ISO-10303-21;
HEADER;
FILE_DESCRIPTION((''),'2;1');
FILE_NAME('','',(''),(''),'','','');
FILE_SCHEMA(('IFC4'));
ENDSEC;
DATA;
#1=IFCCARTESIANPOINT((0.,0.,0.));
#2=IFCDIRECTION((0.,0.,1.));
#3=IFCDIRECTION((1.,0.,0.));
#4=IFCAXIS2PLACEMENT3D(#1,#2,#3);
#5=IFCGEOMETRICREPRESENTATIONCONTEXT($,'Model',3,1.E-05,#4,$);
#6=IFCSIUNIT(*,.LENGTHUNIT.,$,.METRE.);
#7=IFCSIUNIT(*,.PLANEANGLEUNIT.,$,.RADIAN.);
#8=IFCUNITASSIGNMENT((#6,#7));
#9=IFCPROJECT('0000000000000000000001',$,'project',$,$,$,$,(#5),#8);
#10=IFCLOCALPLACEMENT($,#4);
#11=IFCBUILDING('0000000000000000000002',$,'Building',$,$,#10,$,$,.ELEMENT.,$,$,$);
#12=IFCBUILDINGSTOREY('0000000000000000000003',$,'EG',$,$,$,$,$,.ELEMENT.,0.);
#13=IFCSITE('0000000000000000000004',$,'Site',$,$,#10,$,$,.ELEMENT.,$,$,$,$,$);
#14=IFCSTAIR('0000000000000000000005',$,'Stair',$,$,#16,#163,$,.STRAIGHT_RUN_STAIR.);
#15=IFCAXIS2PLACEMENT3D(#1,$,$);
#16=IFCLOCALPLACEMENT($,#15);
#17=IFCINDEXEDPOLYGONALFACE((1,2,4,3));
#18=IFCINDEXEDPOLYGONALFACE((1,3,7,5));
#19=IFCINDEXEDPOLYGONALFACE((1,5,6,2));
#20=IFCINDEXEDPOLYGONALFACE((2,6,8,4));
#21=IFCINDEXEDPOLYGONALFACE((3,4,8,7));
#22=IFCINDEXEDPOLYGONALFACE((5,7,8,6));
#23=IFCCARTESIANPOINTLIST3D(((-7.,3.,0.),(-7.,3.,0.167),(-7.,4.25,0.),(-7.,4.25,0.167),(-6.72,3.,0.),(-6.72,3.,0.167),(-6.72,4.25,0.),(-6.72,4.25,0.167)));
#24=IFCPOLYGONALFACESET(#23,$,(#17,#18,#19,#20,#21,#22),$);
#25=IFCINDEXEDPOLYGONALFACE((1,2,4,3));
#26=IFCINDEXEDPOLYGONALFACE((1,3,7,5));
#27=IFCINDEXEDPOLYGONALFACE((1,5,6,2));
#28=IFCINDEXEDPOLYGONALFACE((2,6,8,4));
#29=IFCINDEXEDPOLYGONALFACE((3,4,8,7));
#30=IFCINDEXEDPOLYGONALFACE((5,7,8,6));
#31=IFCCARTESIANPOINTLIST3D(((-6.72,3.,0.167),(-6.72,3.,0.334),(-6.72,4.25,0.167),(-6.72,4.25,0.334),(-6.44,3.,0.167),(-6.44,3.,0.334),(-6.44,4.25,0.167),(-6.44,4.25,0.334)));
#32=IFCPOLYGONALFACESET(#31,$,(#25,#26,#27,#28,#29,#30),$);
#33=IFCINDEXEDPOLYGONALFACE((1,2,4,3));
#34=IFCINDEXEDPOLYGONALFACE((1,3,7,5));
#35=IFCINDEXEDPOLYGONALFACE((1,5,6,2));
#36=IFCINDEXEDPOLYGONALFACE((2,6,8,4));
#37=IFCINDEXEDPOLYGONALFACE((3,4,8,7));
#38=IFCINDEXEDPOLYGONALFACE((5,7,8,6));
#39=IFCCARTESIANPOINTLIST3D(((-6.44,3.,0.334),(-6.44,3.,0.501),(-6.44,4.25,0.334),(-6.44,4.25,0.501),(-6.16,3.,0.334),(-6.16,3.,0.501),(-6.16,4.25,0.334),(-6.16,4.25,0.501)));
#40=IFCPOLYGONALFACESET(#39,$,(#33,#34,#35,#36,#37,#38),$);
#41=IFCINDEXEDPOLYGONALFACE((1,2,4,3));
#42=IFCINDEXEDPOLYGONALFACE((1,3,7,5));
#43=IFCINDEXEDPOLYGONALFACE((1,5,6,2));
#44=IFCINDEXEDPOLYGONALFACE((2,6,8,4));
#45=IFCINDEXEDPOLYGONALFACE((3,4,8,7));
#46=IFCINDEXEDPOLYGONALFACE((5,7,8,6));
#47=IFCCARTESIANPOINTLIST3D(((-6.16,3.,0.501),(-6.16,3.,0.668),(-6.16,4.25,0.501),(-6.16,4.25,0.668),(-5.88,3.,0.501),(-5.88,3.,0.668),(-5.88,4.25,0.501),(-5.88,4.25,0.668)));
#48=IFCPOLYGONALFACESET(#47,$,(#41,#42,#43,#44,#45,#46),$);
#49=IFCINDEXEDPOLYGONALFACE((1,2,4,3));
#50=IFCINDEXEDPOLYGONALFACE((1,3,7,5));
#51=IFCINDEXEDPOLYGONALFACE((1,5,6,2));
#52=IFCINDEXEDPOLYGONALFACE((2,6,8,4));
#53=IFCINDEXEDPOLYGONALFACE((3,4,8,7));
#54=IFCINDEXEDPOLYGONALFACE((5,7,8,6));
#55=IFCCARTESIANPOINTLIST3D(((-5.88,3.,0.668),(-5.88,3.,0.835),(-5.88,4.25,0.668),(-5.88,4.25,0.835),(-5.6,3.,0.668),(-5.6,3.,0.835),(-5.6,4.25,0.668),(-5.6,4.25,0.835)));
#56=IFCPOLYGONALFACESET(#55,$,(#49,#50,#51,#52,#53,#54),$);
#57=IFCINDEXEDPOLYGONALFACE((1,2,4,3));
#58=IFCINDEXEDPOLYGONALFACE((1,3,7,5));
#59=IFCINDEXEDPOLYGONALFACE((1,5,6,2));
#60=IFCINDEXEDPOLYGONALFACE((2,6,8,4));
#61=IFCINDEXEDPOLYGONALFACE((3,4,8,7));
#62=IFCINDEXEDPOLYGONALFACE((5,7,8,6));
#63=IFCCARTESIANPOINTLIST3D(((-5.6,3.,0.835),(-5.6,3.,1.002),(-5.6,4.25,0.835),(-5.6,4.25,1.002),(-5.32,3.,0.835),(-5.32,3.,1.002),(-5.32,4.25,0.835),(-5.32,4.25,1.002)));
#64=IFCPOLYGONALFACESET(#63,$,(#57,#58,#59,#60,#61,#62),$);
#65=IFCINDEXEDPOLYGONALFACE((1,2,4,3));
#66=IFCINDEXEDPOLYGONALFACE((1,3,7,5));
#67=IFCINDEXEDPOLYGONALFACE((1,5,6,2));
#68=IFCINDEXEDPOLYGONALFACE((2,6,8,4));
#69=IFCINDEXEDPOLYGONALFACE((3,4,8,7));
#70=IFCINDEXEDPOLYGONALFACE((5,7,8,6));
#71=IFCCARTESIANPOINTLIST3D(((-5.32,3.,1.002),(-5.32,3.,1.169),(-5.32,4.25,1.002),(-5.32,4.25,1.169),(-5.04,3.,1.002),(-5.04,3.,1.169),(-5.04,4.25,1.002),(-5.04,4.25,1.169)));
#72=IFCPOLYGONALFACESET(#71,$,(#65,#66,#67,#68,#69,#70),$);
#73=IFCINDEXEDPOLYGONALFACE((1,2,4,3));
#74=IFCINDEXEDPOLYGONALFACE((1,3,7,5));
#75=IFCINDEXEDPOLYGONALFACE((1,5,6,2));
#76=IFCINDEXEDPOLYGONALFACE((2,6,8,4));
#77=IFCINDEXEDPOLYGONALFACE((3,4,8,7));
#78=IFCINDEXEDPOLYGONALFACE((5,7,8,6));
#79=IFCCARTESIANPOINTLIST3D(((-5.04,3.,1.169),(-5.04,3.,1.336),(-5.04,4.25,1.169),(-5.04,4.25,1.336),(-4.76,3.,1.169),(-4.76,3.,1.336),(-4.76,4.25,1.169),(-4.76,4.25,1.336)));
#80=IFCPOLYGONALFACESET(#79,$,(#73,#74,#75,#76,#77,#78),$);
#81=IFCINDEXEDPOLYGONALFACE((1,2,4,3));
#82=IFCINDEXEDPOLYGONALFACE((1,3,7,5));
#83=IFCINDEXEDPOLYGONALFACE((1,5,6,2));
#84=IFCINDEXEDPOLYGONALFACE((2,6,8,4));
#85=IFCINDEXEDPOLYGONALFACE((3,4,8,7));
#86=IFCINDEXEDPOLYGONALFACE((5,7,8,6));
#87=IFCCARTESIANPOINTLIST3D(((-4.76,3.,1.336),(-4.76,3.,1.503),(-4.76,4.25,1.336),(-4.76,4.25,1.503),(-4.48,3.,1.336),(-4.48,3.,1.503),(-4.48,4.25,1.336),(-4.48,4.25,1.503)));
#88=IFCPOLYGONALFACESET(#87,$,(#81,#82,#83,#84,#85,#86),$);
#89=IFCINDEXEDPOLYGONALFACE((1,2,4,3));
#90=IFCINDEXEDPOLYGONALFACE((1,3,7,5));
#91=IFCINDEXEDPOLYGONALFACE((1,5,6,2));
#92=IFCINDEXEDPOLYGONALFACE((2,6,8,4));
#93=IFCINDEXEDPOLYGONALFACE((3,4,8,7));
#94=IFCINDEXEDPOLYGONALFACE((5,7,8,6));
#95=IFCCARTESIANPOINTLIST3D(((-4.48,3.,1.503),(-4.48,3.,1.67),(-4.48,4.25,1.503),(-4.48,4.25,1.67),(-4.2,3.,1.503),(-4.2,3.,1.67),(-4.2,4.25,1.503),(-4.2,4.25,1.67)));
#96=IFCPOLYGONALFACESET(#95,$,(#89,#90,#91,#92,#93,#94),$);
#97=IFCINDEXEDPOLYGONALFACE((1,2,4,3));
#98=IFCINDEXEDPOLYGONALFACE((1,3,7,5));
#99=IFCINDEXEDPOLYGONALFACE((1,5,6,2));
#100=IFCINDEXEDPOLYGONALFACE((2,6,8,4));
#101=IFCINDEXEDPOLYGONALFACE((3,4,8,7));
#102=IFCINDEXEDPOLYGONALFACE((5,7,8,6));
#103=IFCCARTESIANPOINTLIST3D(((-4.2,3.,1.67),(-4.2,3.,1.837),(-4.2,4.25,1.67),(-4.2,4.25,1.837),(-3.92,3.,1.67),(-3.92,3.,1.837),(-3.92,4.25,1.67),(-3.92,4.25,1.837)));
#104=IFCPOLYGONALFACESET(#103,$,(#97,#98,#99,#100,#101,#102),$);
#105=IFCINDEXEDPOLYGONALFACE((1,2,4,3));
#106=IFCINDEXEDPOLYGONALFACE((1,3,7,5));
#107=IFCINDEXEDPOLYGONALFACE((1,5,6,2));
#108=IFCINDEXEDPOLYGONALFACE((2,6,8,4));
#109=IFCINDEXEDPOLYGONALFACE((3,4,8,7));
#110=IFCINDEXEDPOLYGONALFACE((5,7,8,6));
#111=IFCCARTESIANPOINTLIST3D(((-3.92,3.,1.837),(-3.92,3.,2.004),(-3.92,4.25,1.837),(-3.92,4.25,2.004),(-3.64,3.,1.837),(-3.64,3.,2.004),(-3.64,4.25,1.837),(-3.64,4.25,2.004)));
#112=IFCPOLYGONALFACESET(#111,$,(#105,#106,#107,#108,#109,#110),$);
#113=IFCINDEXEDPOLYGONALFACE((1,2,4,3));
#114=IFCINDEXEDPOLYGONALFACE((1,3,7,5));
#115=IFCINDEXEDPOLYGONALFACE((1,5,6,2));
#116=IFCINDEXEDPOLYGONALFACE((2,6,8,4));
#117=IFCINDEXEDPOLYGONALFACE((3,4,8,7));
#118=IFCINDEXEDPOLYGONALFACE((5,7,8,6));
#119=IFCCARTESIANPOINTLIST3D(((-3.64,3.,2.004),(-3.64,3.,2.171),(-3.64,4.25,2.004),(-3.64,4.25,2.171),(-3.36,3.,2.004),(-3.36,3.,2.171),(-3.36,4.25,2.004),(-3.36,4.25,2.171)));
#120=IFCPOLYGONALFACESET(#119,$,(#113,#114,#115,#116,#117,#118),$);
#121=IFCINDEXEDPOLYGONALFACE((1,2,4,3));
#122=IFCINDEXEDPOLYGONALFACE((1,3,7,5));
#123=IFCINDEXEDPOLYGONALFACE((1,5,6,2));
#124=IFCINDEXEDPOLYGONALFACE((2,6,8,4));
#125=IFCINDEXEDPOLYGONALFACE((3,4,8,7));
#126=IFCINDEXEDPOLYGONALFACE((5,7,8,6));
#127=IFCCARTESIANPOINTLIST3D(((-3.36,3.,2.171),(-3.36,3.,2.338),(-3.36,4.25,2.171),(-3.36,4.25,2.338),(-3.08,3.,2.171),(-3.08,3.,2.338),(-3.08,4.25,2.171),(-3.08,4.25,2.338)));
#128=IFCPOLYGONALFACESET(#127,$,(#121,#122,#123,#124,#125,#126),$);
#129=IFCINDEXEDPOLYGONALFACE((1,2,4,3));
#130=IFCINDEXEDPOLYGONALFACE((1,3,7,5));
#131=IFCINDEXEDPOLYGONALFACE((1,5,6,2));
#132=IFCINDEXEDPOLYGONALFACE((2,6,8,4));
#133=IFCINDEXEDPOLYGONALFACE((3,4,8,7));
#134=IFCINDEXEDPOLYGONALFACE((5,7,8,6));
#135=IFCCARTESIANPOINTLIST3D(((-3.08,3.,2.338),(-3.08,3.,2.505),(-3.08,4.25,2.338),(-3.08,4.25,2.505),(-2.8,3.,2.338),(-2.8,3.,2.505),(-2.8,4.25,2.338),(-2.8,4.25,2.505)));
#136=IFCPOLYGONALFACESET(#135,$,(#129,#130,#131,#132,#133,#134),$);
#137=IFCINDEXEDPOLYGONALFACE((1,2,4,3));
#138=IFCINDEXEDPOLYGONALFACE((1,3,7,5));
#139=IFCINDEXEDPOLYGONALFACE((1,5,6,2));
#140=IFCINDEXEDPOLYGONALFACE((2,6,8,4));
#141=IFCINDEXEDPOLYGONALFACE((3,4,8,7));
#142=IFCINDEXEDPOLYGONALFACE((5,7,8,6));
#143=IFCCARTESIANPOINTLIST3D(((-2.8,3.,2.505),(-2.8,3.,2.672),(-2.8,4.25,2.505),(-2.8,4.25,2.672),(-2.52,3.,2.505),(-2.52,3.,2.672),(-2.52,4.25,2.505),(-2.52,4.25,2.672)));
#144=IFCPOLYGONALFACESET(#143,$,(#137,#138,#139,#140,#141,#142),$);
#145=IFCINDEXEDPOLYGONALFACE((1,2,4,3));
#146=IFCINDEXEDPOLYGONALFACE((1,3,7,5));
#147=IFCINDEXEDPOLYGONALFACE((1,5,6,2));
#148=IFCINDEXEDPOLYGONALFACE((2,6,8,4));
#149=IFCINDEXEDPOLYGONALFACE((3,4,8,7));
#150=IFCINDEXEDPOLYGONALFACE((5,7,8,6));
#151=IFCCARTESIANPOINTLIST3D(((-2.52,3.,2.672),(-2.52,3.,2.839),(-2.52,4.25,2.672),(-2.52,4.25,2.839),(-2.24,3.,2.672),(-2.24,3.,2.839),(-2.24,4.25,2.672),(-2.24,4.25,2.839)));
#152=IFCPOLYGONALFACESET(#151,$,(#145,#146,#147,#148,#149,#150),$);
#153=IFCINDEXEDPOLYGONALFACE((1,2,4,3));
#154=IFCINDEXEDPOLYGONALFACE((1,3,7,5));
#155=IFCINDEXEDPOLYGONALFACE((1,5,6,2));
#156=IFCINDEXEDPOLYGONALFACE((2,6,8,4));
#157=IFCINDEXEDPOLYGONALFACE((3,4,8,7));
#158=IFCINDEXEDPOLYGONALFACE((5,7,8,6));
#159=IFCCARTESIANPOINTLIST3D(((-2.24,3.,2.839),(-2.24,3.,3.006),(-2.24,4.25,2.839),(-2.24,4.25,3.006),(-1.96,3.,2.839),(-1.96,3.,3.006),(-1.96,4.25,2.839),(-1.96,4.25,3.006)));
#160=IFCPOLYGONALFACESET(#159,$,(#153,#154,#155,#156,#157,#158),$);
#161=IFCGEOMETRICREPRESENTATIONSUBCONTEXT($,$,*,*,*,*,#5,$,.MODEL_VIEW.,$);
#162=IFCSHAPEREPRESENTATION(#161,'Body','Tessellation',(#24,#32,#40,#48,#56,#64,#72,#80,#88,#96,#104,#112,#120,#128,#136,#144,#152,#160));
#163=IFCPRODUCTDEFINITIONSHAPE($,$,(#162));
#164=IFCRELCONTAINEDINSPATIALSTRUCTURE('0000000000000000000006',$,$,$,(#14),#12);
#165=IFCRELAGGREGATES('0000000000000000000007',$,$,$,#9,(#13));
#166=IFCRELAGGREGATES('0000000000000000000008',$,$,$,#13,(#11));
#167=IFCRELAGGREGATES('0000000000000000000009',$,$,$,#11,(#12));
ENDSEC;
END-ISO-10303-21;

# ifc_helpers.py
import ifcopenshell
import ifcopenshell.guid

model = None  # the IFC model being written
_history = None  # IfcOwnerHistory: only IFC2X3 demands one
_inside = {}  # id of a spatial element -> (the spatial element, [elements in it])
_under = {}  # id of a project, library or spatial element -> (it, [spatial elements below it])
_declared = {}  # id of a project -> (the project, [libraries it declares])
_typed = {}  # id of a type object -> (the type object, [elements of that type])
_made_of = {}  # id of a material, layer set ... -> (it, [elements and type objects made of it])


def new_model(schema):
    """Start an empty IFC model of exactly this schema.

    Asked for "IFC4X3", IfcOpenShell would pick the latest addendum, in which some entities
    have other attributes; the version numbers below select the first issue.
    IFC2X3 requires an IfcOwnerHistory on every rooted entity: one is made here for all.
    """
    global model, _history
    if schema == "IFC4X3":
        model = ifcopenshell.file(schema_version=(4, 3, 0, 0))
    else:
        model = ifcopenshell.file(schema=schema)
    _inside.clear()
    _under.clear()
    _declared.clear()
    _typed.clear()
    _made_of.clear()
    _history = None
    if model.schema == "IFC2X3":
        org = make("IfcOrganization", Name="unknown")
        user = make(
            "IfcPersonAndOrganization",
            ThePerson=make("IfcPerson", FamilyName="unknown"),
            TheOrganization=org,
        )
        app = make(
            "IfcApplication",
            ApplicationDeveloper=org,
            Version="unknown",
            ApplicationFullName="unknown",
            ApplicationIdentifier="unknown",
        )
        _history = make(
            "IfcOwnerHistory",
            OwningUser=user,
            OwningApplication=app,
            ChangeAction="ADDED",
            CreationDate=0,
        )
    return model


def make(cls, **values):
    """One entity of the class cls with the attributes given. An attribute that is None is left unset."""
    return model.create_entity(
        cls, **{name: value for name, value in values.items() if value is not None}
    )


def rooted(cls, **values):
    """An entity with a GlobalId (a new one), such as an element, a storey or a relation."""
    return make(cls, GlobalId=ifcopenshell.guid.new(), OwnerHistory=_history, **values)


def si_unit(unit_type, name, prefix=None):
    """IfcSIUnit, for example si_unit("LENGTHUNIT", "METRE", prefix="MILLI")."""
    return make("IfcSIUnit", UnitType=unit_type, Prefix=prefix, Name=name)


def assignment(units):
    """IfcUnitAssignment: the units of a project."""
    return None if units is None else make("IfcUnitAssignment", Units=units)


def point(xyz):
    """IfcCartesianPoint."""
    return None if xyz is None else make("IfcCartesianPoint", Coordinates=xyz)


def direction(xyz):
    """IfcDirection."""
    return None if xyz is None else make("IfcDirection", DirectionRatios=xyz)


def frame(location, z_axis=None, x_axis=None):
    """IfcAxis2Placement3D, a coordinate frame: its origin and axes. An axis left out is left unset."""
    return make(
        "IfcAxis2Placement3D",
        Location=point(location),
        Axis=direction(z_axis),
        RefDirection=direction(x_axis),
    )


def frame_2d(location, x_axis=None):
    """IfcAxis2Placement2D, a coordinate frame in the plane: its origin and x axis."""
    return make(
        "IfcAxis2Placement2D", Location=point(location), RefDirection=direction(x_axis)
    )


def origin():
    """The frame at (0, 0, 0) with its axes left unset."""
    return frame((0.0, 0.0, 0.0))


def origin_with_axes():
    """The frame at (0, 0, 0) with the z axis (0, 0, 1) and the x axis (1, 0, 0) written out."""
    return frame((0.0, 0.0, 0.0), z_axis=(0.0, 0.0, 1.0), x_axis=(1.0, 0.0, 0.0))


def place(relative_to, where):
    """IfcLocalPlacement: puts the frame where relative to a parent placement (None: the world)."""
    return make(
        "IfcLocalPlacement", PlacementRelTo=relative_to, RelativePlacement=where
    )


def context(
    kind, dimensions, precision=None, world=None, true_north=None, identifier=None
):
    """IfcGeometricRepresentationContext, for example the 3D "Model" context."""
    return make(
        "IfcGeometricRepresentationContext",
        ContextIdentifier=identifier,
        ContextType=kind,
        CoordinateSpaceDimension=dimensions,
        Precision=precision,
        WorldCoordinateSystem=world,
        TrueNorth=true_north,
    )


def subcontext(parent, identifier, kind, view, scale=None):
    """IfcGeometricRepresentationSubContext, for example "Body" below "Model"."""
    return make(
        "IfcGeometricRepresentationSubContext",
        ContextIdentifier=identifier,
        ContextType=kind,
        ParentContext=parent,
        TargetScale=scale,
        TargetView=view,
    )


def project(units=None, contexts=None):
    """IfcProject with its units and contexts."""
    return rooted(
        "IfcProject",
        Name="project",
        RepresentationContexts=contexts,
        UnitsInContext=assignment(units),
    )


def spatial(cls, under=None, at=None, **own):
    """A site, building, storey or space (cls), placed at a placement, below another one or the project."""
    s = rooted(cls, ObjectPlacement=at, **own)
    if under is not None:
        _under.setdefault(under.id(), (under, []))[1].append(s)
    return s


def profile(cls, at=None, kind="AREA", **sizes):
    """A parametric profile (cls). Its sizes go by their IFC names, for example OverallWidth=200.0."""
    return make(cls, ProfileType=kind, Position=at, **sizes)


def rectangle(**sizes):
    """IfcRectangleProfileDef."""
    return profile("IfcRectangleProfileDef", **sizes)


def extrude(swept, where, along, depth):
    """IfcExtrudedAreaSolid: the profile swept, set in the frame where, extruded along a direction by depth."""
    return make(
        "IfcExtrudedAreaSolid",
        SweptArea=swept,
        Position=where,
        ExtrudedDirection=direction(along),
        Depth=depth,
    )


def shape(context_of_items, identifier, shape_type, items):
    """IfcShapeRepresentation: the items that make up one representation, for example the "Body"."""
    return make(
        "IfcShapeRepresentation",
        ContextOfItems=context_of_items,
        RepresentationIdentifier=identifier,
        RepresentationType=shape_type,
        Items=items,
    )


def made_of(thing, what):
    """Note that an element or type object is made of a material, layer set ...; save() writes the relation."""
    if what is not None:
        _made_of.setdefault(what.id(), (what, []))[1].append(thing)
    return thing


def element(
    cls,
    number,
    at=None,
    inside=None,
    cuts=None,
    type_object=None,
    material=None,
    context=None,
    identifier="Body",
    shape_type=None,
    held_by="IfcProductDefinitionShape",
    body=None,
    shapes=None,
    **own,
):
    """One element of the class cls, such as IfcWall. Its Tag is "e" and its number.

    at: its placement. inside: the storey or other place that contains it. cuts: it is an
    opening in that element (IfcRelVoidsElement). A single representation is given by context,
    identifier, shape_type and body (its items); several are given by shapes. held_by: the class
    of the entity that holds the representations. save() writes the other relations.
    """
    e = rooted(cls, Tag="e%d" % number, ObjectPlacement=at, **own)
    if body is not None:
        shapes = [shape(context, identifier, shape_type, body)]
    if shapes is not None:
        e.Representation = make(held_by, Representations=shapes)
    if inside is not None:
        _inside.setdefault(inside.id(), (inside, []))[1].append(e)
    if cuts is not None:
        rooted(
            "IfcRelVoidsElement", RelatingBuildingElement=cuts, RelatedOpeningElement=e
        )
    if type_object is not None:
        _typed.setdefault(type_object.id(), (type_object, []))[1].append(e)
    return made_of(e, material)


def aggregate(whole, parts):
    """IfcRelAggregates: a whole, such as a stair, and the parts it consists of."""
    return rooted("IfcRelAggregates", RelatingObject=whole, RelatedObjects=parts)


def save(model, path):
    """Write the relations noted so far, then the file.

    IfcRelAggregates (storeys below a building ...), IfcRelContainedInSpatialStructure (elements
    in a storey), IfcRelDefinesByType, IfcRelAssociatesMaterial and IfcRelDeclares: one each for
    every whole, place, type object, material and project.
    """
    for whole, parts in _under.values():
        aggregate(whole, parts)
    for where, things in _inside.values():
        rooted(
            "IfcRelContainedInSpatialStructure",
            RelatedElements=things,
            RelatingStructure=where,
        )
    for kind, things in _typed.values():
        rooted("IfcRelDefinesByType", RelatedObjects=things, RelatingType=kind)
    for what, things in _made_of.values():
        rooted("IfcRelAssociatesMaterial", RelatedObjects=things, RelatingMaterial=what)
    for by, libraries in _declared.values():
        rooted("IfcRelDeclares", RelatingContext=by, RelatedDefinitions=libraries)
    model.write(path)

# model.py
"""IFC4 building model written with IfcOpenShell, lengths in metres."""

from ifc_helpers import new_model, si_unit, frame, frame_2d, origin, origin_with_axes, place, context, subcontext, project, spatial, rectangle, extrude, element, save


model = new_model("IFC4")

# Units and contexts
model_context = context("Model", 3, precision=1e-05, world=origin_with_axes())
sub_context = subcontext(model_context, None, None, "MODEL_VIEW")
ifc_project = project(units=[si_unit("LENGTHUNIT", "METRE"), si_unit("PLANEANGLEUNIT", "RADIAN")], contexts=[model_context])

# Site, building, storey
placement_1 = place(None, origin_with_axes())
site = spatial("IfcSite", under=ifc_project, at=placement_1, Name="Site", CompositionType="ELEMENT")
building = spatial("IfcBuilding", under=site, at=placement_1, Name="Building", CompositionType="ELEMENT")
storey = spatial("IfcBuildingStorey", under=building, Name="EG", CompositionType="ELEMENT", Elevation=0.0)

# Stair
placement_2 = place(None, origin_with_axes())
placement_3 = place(placement_2, origin())
stair_placement = place(placement_3, frame((-7.0, 3.0, 0.0)))
element("IfcStair", 1, at=stair_placement, inside=storey, Name="Stair", PredefinedType="STRAIGHT_RUN_STAIR", context=sub_context, shape_type="SolidModel", body=[
    extrude(rectangle(XDim=0.28, YDim=1.25, at=frame_2d((0.14, 0.625))), origin(), (0.0, 0.0, 1.0), 0.167),
    extrude(rectangle(XDim=0.28, YDim=1.25, at=frame_2d((0.14, 0.625))), frame((0.28, 0.0, 0.167)), (0.0, 0.0, 1.0), 0.167),
    extrude(rectangle(XDim=0.28, YDim=1.25, at=frame_2d((0.14, 0.625))), frame((0.56, 0.0, 0.334)), (0.0, 0.0, 1.0), 0.167),
    extrude(rectangle(XDim=0.28, YDim=1.25, at=frame_2d((0.14, 0.625))), frame((0.84, 0.0, 0.501)), (0.0, 0.0, 1.0), 0.167),
    extrude(rectangle(XDim=0.28, YDim=1.25, at=frame_2d((0.14, 0.625))), frame((1.12, 0.0, 0.668)), (0.0, 0.0, 1.0), 0.167),
    extrude(rectangle(XDim=0.28, YDim=1.25, at=frame_2d((0.14, 0.625))), frame((1.4, 0.0, 0.835)), (0.0, 0.0, 1.0), 0.167),
    extrude(rectangle(XDim=0.28, YDim=1.25, at=frame_2d((0.14, 0.625))), frame((1.68, 0.0, 1.002)), (0.0, 0.0, 1.0), 0.167),
    extrude(rectangle(XDim=0.28, YDim=1.25, at=frame_2d((0.14, 0.625))), frame((1.96, 0.0, 1.169)), (0.0, 0.0, 1.0), 0.167),
    extrude(rectangle(XDim=0.28, YDim=1.25, at=frame_2d((0.14, 0.625))), frame((2.24, 0.0, 1.336)), (0.0, 0.0, 1.0), 0.167),
    extrude(rectangle(XDim=0.28, YDim=1.25, at=frame_2d((0.14, 0.625))), frame((2.52, 0.0, 1.503)), (0.0, 0.0, 1.0), 0.167),
    extrude(rectangle(XDim=0.28, YDim=1.25, at=frame_2d((0.14, 0.625))), frame((2.8, 0.0, 1.67)), (0.0, 0.0, 1.0), 0.167),
    extrude(rectangle(XDim=0.28, YDim=1.25, at=frame_2d((0.14, 0.625))), frame((3.08, 0.0, 1.837)), (0.0, 0.0, 1.0), 0.167),
    extrude(rectangle(XDim=0.28, YDim=1.25, at=frame_2d((0.14, 0.625))), frame((3.36, 0.0, 2.004)), (0.0, 0.0, 1.0), 0.167),
    extrude(rectangle(XDim=0.28, YDim=1.25, at=frame_2d((0.14, 0.625))), frame((3.64, 0.0, 2.171)), (0.0, 0.0, 1.0), 0.167),
    extrude(rectangle(XDim=0.28, YDim=1.25, at=frame_2d((0.14, 0.625))), frame((3.92, 0.0, 2.338)), (0.0, 0.0, 1.0), 0.167),
    extrude(rectangle(XDim=0.28, YDim=1.25, at=frame_2d((0.14, 0.625))), frame((4.2, 0.0, 2.505)), (0.0, 0.0, 1.0), 0.167),
    extrude(rectangle(XDim=0.28, YDim=1.25, at=frame_2d((0.14, 0.625))), frame((4.48, 0.0, 2.672)), (0.0, 0.0, 1.0), 0.167),
    extrude(rectangle(XDim=0.28, YDim=1.25, at=frame_2d((0.14, 0.625))), frame((4.76, 0.0, 2.839)), (0.0, 0.0, 1.0), 0.167),
])

save(model, "model.ifc")
